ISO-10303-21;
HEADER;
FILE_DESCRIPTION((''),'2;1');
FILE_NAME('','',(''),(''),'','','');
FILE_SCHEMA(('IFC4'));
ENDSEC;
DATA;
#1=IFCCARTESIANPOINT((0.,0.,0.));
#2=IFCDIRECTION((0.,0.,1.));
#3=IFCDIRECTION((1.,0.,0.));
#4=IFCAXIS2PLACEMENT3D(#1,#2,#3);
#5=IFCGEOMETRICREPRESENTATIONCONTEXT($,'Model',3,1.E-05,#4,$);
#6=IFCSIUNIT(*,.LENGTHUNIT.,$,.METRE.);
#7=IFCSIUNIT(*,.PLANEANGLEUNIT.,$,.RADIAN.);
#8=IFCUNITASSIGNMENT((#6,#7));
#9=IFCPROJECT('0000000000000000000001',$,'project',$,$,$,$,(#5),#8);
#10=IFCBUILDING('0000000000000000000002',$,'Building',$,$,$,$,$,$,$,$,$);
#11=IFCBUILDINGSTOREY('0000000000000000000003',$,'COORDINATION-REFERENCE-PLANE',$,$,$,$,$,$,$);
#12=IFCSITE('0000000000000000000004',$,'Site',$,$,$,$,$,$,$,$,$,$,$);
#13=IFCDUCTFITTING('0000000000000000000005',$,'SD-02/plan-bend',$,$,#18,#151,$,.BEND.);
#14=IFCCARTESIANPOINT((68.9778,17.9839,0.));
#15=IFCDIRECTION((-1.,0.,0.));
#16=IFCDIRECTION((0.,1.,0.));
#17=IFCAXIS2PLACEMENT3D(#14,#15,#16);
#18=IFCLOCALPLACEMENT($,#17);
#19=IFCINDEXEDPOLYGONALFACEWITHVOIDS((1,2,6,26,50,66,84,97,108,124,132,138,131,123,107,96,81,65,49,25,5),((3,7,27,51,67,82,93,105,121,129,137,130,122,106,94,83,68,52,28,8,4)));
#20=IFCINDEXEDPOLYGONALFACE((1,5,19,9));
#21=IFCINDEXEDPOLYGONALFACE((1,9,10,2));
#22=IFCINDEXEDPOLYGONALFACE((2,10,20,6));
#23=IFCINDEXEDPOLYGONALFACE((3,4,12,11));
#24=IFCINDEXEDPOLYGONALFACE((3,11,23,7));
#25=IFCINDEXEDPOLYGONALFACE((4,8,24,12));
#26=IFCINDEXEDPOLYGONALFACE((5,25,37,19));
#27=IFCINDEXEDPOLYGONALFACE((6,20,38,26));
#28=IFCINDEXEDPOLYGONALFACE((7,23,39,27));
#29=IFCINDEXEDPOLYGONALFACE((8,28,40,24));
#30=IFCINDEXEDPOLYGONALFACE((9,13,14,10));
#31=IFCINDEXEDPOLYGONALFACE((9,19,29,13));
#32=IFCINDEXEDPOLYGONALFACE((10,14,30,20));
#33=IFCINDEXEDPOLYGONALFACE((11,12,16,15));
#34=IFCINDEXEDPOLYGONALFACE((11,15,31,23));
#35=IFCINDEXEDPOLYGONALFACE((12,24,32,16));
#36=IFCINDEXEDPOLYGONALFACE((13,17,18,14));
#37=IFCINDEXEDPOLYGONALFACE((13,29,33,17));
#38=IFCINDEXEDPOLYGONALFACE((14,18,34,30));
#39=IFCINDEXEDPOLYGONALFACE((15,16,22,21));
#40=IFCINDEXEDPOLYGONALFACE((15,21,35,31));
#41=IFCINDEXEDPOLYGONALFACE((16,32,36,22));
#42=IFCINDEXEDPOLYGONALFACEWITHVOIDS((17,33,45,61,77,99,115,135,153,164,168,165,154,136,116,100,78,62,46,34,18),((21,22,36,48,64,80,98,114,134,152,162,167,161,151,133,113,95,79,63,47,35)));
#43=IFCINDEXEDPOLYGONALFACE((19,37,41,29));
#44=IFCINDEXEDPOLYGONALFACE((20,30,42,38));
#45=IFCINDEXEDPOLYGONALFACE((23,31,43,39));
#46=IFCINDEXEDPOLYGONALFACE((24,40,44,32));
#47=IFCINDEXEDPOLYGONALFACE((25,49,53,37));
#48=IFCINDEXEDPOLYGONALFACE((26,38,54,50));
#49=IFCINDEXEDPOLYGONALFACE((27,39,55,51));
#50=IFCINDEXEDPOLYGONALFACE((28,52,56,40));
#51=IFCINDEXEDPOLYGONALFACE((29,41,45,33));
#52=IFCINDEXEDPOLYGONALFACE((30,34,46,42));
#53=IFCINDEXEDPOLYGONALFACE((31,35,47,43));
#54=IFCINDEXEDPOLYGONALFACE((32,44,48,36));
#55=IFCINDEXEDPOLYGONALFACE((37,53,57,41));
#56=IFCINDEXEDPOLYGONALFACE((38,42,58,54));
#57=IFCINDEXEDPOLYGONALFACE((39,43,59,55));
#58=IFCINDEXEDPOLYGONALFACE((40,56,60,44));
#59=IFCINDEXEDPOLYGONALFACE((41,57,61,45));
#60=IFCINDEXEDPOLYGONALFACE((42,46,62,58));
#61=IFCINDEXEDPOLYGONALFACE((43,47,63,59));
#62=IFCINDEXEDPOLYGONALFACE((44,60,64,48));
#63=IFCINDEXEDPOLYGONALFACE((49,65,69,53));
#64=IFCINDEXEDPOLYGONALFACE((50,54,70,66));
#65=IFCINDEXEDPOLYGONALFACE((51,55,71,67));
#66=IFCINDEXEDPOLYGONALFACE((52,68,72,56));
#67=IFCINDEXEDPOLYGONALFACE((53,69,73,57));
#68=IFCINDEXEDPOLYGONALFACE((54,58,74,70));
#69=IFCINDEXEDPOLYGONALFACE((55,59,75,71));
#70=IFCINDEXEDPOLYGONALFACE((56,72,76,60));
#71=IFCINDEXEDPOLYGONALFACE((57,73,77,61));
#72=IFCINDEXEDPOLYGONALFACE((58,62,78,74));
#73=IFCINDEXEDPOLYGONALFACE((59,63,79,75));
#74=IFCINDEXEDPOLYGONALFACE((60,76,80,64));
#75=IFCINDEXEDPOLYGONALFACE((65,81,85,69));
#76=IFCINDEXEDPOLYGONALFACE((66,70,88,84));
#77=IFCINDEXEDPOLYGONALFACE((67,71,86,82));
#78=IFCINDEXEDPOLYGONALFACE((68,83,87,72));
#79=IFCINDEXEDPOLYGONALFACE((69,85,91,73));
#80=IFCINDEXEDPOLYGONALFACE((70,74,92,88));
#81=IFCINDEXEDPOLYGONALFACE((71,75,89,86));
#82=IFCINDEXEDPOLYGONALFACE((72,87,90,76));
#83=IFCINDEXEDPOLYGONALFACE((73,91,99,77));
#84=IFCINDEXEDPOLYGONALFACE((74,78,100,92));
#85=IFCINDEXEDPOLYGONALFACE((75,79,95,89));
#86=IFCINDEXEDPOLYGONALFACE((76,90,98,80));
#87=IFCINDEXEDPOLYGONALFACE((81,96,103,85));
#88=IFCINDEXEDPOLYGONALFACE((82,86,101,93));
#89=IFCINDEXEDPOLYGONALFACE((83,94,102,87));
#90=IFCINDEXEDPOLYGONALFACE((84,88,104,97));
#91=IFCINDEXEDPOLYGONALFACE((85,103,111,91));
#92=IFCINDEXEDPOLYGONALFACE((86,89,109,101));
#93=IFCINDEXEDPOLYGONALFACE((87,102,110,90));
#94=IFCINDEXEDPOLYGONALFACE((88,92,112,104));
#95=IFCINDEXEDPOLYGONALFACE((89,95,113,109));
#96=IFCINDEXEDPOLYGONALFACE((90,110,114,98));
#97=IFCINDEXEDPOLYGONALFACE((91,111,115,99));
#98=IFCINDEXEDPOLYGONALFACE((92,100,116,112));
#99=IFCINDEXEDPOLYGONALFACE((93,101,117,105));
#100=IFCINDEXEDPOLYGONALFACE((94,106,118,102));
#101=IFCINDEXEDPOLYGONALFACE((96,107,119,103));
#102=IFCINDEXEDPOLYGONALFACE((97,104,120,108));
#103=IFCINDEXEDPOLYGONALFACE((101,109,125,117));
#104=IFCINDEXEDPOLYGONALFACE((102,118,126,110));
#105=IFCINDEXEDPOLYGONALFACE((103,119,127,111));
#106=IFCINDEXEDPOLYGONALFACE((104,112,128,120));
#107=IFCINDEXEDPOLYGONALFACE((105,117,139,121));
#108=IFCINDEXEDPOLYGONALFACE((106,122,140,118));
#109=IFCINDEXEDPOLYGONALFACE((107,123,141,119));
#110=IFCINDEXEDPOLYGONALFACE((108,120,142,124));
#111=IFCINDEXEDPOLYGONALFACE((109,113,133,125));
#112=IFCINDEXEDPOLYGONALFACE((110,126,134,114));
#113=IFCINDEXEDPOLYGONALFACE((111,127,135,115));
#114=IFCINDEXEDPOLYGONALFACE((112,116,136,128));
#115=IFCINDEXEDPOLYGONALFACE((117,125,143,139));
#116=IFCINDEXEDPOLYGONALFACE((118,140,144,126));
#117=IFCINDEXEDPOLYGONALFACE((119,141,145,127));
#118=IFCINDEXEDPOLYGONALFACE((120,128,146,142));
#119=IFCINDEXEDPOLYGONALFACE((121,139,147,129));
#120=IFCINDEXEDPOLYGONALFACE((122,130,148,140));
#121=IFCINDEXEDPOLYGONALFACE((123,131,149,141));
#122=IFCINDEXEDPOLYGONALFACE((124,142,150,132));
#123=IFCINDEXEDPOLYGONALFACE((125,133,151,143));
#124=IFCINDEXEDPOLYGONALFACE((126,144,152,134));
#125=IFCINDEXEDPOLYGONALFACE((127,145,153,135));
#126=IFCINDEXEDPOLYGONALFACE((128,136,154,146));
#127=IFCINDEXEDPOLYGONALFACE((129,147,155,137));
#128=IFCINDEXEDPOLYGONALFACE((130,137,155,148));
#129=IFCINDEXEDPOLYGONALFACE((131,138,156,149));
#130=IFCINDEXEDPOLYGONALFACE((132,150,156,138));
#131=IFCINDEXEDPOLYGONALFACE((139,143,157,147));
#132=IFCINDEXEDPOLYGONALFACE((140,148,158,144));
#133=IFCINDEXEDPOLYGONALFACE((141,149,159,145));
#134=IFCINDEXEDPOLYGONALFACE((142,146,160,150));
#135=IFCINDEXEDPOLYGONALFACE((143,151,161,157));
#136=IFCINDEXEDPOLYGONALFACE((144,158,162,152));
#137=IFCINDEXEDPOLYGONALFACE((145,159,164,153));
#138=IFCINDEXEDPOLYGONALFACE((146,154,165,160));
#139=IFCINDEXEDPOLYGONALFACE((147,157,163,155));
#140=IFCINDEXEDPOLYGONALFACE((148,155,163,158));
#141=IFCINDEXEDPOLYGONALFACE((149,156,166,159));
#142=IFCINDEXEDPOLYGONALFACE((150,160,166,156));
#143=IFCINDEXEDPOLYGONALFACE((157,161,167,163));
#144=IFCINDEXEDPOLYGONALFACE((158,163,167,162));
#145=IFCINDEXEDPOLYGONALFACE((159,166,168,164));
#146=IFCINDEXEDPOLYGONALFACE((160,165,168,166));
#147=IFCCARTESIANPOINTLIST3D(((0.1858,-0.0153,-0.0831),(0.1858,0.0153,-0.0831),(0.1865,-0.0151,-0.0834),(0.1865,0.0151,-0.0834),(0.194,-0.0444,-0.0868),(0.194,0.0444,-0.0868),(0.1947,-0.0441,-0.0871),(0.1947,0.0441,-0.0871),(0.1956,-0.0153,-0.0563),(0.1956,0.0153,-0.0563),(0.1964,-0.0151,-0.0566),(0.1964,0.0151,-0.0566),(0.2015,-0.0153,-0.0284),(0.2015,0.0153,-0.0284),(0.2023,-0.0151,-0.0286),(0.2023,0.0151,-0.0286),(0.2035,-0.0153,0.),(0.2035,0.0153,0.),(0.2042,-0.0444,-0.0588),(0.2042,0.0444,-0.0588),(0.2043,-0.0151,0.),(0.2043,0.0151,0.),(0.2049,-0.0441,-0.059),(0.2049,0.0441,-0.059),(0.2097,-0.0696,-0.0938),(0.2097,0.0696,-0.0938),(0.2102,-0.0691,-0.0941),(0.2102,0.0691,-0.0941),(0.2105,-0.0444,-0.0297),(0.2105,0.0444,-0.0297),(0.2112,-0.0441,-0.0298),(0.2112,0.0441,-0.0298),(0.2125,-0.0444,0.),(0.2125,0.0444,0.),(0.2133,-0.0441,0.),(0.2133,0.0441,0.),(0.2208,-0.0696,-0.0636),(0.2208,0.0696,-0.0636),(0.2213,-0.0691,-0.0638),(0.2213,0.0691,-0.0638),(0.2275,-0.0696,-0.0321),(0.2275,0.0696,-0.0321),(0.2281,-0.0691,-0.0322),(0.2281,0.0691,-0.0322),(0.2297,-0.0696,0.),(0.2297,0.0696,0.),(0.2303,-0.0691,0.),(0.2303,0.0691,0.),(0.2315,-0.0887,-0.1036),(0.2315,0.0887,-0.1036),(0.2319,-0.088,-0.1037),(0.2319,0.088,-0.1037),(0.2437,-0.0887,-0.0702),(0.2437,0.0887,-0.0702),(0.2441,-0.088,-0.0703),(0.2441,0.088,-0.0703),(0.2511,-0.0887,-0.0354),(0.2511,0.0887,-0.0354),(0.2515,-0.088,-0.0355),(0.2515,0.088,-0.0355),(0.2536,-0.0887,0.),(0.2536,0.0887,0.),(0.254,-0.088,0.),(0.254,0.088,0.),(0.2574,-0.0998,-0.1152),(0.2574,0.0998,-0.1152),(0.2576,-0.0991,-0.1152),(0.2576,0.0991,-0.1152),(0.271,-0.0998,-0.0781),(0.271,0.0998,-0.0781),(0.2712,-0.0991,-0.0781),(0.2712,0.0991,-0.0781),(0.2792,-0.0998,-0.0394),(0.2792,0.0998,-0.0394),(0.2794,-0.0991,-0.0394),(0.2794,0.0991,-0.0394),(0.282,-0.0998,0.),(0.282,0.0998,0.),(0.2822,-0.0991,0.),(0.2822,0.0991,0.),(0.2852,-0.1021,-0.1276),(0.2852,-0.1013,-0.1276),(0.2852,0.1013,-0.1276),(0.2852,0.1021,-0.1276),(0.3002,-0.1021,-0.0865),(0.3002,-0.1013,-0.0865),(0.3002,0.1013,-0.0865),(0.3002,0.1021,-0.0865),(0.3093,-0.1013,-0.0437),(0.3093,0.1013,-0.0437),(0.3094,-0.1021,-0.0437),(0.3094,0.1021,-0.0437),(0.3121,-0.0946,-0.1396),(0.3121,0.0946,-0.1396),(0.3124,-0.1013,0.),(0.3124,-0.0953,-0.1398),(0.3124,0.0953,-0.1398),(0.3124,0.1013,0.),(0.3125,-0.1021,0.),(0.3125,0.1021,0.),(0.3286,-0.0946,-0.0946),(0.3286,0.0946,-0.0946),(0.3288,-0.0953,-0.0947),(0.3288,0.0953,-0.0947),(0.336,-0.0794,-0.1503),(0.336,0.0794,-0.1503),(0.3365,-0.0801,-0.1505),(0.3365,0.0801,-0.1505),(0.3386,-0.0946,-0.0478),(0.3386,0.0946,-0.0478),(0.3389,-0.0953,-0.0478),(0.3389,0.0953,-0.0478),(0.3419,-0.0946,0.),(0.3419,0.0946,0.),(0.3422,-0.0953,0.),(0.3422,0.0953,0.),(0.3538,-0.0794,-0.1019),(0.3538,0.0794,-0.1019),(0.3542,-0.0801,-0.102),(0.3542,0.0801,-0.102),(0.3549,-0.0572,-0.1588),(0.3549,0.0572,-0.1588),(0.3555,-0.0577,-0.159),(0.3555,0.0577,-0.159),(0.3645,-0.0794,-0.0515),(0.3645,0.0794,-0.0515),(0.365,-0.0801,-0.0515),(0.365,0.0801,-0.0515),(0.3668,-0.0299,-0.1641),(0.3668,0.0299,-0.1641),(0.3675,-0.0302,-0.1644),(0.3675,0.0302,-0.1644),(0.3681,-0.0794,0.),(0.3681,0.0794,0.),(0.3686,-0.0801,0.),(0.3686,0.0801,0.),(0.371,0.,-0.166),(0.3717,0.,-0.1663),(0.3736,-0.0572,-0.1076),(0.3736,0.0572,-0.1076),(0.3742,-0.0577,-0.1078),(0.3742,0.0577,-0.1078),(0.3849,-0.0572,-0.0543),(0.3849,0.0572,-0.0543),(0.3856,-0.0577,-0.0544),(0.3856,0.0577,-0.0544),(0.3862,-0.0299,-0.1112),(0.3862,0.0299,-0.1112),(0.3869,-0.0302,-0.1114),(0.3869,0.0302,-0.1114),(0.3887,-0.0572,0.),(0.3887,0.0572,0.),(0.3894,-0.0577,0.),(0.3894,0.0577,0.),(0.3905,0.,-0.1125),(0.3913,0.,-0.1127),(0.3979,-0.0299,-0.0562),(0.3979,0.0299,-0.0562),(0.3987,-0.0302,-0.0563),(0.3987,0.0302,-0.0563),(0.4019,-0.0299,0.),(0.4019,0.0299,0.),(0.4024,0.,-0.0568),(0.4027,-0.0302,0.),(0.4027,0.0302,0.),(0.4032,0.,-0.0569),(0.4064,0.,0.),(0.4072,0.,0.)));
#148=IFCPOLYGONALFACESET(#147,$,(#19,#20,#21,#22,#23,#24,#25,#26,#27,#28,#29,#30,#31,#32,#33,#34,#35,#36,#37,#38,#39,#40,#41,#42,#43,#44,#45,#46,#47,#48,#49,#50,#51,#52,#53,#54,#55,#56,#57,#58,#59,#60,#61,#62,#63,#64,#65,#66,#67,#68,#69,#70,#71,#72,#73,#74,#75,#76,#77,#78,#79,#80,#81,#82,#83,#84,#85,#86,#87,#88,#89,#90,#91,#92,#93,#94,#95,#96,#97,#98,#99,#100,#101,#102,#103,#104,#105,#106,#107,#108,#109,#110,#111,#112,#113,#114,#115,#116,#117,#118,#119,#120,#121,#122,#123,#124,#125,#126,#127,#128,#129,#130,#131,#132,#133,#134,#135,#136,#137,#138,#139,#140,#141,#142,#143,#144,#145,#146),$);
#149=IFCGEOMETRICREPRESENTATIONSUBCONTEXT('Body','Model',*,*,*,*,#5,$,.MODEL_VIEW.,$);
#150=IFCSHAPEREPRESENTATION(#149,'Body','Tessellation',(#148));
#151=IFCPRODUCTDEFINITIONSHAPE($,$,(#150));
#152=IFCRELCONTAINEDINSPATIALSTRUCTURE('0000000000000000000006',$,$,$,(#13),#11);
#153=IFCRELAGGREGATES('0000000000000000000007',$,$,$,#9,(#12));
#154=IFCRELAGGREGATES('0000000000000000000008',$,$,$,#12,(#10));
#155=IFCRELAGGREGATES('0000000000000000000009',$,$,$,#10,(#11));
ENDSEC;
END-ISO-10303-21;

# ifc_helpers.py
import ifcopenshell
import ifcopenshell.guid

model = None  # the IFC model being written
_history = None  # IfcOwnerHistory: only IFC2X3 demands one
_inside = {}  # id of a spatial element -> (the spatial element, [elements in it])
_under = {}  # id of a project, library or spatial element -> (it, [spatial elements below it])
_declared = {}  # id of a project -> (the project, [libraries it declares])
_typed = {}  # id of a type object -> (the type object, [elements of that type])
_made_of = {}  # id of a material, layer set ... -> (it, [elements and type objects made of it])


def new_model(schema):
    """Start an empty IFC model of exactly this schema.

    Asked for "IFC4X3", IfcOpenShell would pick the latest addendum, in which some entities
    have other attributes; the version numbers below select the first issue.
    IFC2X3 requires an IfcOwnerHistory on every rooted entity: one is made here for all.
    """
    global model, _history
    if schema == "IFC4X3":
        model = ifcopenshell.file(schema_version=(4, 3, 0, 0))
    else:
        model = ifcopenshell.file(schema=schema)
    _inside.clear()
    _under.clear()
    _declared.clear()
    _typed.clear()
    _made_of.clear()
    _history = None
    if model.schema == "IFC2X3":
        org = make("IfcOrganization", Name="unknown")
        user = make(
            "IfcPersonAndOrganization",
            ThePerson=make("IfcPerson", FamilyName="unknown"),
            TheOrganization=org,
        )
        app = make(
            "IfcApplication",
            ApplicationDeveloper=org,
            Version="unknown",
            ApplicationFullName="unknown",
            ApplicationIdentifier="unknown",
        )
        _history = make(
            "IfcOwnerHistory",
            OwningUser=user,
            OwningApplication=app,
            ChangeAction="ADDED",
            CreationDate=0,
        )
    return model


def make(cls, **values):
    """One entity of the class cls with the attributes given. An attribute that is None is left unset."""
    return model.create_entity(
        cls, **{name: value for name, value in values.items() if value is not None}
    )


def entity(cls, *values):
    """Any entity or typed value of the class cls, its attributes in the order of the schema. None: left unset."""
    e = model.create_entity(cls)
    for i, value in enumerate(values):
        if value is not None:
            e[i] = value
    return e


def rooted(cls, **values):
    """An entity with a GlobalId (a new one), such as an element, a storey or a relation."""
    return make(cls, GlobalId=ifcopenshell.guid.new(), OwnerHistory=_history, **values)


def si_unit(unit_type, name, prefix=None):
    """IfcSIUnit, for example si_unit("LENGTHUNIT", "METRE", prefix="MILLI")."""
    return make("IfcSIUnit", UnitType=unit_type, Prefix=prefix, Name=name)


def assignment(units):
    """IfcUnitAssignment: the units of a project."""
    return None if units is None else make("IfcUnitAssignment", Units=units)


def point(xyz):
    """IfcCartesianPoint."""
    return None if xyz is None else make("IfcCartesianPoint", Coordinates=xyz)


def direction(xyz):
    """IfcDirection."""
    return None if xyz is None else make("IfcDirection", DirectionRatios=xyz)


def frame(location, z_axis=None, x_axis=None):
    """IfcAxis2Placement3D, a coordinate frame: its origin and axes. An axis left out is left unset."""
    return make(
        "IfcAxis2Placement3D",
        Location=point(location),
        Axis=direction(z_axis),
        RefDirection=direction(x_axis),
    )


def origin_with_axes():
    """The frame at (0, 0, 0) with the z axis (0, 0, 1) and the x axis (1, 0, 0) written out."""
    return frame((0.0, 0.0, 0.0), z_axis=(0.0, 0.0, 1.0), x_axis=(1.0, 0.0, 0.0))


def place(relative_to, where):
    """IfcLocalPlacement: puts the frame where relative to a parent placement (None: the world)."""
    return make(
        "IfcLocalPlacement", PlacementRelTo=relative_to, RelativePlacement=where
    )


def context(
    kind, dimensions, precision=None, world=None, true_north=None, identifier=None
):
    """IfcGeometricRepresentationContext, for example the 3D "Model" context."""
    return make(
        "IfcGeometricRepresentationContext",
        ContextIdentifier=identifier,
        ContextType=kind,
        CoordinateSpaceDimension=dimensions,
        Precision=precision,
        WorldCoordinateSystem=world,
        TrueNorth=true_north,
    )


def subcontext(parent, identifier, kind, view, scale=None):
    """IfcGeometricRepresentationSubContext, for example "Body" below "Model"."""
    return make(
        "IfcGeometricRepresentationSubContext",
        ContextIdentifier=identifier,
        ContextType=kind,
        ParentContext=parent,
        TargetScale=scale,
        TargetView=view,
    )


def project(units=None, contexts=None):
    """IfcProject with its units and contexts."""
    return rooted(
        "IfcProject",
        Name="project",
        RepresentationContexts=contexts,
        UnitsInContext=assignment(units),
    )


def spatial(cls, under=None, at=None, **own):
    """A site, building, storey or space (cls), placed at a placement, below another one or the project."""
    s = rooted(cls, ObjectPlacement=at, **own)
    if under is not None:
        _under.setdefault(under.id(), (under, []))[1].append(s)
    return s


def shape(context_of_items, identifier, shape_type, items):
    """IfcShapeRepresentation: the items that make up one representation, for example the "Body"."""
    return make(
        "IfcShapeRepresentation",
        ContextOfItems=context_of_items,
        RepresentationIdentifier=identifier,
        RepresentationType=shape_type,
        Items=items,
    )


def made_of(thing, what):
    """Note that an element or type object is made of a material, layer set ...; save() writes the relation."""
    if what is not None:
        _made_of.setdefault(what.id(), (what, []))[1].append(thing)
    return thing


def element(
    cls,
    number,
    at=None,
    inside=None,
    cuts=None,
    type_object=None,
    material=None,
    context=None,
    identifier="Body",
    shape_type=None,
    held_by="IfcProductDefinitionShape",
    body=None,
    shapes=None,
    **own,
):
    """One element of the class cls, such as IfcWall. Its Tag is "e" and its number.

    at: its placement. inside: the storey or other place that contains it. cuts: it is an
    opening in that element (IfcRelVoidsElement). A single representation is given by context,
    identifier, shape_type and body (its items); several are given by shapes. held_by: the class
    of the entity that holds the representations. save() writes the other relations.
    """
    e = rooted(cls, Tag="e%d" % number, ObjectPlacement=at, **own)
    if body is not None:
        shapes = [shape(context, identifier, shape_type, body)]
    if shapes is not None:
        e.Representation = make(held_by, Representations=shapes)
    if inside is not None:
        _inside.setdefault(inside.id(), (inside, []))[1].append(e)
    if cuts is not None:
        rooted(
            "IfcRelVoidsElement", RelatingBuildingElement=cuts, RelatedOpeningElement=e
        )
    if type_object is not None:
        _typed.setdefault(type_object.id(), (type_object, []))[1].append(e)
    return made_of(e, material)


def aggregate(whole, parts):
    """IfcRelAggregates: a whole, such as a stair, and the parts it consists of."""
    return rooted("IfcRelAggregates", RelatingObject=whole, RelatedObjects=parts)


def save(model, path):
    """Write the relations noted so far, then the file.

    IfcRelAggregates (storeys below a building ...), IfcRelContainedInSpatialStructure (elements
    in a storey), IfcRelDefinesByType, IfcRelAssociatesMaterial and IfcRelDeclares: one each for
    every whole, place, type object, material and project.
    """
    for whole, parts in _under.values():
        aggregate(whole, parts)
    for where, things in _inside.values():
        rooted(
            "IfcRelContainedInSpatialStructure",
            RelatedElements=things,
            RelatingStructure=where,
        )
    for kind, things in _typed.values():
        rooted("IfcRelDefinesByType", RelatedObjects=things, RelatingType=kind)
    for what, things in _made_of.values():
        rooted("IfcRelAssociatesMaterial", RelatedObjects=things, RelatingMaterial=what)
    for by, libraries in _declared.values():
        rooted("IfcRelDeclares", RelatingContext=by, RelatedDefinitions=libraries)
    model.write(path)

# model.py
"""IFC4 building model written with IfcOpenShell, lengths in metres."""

from ifc_helpers import new_model, entity, si_unit, frame, origin_with_axes, place, context, subcontext, project, spatial, element, save


model = new_model("IFC4")

# Units and contexts
model_context = context("Model", 3, precision=1e-05, world=origin_with_axes())
body_context_1 = subcontext(model_context, "Body", "Model", "MODEL_VIEW")
ifc_project = project(units=[si_unit("LENGTHUNIT", "METRE"), si_unit("PLANEANGLEUNIT", "RADIAN")], contexts=[model_context])

# Site, building, storey
site = spatial("IfcSite", under=ifc_project, Name="Site")
building = spatial("IfcBuilding", under=site, Name="Building")
storey = spatial("IfcBuildingStorey", under=building, Name="COORDINATION-REFERENCE-PLANE")

# Duct fitting
duct_fitting_1_placement = place(None, frame((68.9778, 17.9839, 0.0), z_axis=(-1.0, 0.0, 0.0), x_axis=(0.0, 1.0, 0.0)))
element("IfcDuctFitting", 1, at=duct_fitting_1_placement, inside=storey, Name="SD-02/plan-bend", PredefinedType="BEND", context=body_context_1, shape_type="SweptSolid", body=[
    entity("IfcRevolvedAreaSolid", entity("IfcCircleHollowProfileDef", "AREA", None, entity("IfcAxis2Placement2D", entity("IfcCartesianPoint", [0.3048, 0.0])), 0.1024, 0.0008), entity("IfcAxis2Placement3D", entity("IfcCartesianPoint", [0.0, 0.0, 0.0]), entity("IfcDirection", [0.0, 0.0, 1.0]), entity("IfcDirection", [1.0, 0.0, 0.0])), entity("IfcAxis1Placement", entity("IfcCartesianPoint", [0.0, 0.0, 0.0]), entity("IfcDirection", [0.0, 1.0, 0.0])), 0.420676),
])

save(model, "model.ifc")
